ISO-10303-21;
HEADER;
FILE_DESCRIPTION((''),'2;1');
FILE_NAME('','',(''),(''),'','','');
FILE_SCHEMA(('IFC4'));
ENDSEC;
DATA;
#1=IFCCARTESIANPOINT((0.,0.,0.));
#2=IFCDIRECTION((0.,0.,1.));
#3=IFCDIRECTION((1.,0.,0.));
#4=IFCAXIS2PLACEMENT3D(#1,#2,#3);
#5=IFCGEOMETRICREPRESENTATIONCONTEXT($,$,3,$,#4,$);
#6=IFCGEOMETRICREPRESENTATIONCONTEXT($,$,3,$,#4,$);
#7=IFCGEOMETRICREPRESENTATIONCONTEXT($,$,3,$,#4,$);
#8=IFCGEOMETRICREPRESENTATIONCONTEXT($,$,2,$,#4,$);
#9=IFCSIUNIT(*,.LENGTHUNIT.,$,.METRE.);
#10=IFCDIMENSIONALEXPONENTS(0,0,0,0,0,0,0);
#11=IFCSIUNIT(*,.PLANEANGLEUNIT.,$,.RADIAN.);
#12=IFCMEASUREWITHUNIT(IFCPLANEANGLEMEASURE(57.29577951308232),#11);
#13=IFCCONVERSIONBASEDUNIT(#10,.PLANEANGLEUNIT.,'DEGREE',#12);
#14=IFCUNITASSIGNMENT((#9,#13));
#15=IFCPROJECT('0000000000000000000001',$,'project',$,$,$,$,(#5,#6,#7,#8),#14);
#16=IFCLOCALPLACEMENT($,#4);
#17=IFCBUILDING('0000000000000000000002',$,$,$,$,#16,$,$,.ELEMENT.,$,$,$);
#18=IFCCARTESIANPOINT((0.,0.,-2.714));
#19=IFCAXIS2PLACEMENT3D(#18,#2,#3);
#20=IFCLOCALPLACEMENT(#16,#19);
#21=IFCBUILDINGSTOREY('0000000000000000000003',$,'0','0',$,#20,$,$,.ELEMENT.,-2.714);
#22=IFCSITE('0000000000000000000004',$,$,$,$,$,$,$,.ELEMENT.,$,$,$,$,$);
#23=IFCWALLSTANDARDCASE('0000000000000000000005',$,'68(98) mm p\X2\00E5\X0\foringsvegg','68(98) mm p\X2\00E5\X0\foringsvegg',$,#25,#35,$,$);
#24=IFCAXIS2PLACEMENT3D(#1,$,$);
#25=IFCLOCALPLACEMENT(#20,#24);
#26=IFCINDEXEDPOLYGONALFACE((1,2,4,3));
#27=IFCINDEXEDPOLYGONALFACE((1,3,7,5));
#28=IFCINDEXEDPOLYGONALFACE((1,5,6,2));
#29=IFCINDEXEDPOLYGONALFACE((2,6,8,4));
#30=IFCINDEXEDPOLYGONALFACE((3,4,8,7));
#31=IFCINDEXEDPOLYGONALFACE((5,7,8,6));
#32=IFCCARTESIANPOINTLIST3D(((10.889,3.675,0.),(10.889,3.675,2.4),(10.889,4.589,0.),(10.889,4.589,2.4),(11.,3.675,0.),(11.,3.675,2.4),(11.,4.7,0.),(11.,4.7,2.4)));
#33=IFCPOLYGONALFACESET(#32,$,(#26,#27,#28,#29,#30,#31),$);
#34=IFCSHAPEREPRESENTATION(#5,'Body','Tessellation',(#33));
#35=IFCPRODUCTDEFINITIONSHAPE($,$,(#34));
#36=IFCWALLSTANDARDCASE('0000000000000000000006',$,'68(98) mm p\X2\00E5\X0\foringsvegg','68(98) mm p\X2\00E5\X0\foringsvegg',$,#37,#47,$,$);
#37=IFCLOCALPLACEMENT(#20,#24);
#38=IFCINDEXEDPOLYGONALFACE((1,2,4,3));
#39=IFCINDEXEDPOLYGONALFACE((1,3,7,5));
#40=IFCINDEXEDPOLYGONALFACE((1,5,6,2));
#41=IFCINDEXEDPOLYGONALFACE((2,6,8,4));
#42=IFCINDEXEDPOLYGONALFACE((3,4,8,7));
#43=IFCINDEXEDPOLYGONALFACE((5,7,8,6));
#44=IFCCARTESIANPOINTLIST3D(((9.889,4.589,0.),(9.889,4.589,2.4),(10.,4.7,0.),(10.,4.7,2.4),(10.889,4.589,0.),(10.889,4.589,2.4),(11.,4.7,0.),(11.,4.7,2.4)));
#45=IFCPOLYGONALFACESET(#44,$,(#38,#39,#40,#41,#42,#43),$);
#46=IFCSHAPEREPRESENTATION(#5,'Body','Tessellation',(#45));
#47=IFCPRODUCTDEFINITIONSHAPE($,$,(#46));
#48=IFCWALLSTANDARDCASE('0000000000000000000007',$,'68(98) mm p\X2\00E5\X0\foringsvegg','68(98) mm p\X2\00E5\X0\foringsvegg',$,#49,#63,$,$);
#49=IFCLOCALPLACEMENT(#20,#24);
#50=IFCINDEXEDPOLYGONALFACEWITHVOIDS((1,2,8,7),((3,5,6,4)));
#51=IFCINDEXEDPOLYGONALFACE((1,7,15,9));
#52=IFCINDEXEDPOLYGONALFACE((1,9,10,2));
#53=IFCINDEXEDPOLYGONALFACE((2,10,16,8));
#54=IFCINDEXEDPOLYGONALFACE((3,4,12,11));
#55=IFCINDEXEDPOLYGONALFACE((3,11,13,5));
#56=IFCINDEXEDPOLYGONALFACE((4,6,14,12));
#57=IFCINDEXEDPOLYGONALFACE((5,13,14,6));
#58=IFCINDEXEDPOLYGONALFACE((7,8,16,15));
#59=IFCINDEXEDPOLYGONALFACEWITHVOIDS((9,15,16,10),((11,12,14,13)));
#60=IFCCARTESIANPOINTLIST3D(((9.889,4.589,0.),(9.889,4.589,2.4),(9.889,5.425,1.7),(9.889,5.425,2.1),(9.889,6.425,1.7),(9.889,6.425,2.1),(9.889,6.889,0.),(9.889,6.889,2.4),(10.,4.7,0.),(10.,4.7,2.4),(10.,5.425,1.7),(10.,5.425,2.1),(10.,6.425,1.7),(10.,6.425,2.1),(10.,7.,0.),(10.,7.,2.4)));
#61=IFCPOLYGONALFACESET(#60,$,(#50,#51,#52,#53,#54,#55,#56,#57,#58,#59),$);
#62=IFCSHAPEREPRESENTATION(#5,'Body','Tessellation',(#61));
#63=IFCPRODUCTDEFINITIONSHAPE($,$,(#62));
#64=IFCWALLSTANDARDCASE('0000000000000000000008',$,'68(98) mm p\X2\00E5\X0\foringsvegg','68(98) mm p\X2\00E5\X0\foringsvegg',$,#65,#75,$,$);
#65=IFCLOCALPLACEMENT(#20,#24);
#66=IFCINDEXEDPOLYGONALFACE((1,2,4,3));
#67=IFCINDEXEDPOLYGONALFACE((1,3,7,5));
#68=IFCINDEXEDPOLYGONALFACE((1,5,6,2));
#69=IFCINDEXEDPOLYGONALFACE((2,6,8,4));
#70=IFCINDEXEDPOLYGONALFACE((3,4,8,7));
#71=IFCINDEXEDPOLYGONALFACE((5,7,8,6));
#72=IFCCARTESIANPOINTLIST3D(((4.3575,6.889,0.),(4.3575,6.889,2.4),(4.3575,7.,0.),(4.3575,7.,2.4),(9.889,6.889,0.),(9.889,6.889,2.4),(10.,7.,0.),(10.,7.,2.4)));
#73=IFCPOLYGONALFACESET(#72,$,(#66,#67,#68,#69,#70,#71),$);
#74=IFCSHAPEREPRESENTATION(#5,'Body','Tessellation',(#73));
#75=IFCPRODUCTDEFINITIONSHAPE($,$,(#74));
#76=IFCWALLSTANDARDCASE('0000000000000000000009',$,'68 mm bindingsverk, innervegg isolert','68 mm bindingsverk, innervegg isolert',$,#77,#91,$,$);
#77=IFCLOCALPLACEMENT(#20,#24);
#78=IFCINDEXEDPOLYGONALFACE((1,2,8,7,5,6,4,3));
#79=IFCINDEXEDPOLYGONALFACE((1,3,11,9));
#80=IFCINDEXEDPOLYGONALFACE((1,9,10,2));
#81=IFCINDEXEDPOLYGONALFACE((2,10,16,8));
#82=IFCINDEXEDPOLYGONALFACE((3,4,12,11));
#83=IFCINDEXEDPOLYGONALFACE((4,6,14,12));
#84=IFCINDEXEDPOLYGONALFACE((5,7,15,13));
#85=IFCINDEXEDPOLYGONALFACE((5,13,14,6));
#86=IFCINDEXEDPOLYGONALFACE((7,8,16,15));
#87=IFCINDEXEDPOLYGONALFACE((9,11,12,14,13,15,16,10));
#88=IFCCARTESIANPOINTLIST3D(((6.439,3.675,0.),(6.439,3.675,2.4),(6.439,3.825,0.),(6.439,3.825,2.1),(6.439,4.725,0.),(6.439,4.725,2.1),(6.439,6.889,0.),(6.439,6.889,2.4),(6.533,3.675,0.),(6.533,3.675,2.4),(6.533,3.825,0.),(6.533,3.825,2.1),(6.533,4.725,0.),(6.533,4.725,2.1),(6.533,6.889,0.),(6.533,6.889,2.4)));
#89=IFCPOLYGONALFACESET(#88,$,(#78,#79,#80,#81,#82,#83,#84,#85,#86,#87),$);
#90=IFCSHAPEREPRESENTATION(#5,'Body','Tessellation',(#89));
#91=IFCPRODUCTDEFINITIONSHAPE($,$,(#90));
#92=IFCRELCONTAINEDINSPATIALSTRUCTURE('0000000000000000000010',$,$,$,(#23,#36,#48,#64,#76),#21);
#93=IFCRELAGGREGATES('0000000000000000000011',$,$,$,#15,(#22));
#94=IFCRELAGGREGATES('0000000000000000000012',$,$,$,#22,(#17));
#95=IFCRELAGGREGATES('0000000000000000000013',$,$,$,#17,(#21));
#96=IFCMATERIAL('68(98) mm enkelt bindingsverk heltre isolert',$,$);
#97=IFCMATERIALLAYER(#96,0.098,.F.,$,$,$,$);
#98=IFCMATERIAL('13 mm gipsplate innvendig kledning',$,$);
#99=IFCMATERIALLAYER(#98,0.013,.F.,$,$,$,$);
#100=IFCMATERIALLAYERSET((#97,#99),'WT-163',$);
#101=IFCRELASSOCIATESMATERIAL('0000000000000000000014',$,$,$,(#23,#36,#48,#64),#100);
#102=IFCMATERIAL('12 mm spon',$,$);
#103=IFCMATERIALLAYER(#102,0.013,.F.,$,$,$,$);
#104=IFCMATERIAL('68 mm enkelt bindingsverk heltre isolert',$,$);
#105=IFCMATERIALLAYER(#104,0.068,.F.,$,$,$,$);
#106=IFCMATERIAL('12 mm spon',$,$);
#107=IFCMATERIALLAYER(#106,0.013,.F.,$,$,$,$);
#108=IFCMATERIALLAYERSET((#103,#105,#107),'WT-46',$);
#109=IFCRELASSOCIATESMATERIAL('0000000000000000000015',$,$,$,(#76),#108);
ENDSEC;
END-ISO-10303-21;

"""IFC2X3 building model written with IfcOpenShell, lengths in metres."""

from ifc_helpers import new_model, entity, si_unit, converted_unit, frame, origin_with_axes, place, context, project, spatial, polyline, outline, extrude, material, layer, layer_set, layer_usage, element, save


model = new_model("IFC2X3")

# Units and contexts
context_of_model_1 = context(None, 3, world=origin_with_axes())
context_of_model_2 = context(None, 3, world=origin_with_axes())
context_of_model_3 = context(None, 3, world=origin_with_axes())
context_of_model_4 = context(None, 2, world=origin_with_axes())
ifc_project = project(units=[si_unit("LENGTHUNIT", "METRE"), converted_unit("PLANEANGLEUNIT", "DEGREE", entity("IfcPlaneAngleMeasure", 57.29577951308232), si_unit("PLANEANGLEUNIT", "RADIAN"), dimensions=[0, 0, 0, 0, 0, 0, 0])], contexts=[context_of_model_1, context_of_model_2, context_of_model_3, context_of_model_4])

# Site, building, storey
site = spatial("IfcSite", under=ifc_project, CompositionType="ELEMENT")
building_placement = place(None, origin_with_axes())
building = spatial("IfcBuilding", under=site, at=building_placement, CompositionType="ELEMENT")
storey_placement = place(building_placement, frame((0.0, 0.0, -2.714), z_axis=(0.0, 0.0, 1.0), x_axis=(1.0, 0.0, 0.0)))
storey = spatial("IfcBuildingStorey", under=building, at=storey_placement, Name="0", Description="0", CompositionType="ELEMENT", Elevation=-2.714)

# Walls
ifc_material_1 = material(Name="68(98) mm enkelt bindingsverk heltre isolert")
ifc_layer_1 = layer(ifc_material_1, 0.098, ventilated=False)
ifc_material_2 = material(Name="13 mm gipsplate innvendig kledning")
ifc_layer_2 = layer(ifc_material_2, 0.013, ventilated=False)
ifc_layer_set_1 = layer_set([ifc_layer_1, ifc_layer_2], Name="WT-163")
ifc_layer_usage_1 = layer_usage(ifc_layer_set_1, "AXIS2", "POSITIVE", 0.0)
wall_1_placement = place(storey_placement, frame((11.0, 3.675, 0.0), z_axis=(0.0, 0.0, 1.0), x_axis=(0.0, 1.0, 0.0)))
element("IfcWallStandardCase", 1, at=wall_1_placement, inside=storey, material=ifc_layer_usage_1, Name="68(98) mm påforingsvegg", Description="68(98) mm påforingsvegg", context=context_of_model_1, shape_type="SweptSolid", body=[
    extrude(outline(polyline([(0.0, 0.0), (1.025, 0.0), (0.914, 0.111), (0.0, 0.111), (0.0, 0.0)])), frame((0.0, 0.0, 0.0), z_axis=(0.0, 0.0, 1.0), x_axis=(1.0, 0.0, 0.0)), (0.0, 0.0, 1.0), 2.4),
])
wall_2_placement = place(storey_placement, frame((11.0, 4.7, 0.0), z_axis=(0.0, 0.0, 1.0), x_axis=(-1.0, 0.0, 0.0)))
element("IfcWallStandardCase", 2, at=wall_2_placement, inside=storey, material=ifc_layer_usage_1, Name="68(98) mm påforingsvegg", Description="68(98) mm påforingsvegg", context=context_of_model_1, shape_type="SweptSolid", body=[
    extrude(outline(polyline([(0.0, 0.0), (1.0, 0.0), (1.111, 0.111), (0.111, 0.111), (0.0, 0.0)])), frame((0.0, 0.0, 0.0), z_axis=(0.0, 0.0, 1.0), x_axis=(1.0, 0.0, 0.0)), (0.0, 0.0, 1.0), 2.4),
])

# Wall, opening
wall_3_placement = place(storey_placement, frame((10.0, 4.7, 0.0), z_axis=(0.0, 0.0, 1.0), x_axis=(0.0, 1.0, 0.0)))
wall_3 = element("IfcWallStandardCase", 3, at=wall_3_placement, inside=storey, material=ifc_layer_usage_1, Name="68(98) mm påforingsvegg", Description="68(98) mm påforingsvegg", context=context_of_model_1, shape_type="SweptSolid", body=[
    extrude(outline(polyline([(0.0, 0.0), (2.3, 0.0), (2.189, 0.111), (-0.111, 0.111), (0.0, 0.0)])), frame((0.0, 0.0, 0.0), z_axis=(0.0, 0.0, 1.0), x_axis=(1.0, 0.000001, 0.0)), (0.0, 0.0, 1.0), 2.4),
])
opening_1_placement = place(wall_3_placement, frame((0.725, 0.0, 1.7), z_axis=(0.0, 0.0, 1.0), x_axis=(1.0, 0.0, 0.0)))
element("IfcOpeningElement", 4, at=opening_1_placement, inside=storey, cuts=wall_3, context=context_of_model_1, shape_type="SweptSolid", body=[
    extrude(outline(polyline([(0.0, 0.0), (0.4, 0.0), (0.4, 1.0), (0.0, 1.0), (0.0, 0.0)])), frame((0.0, 0.0, 0.0), z_axis=(-0.000001, 1.0, 0.0), x_axis=(0.0, 0.0, 1.0)), (0.0, 0.000001, 1.0), 0.111),
])

# Wall
wall_4_placement = place(storey_placement, frame((10.0, 7.0, 0.0), z_axis=(0.0, 0.0, 1.0), x_axis=(-1.0, 0.0, 0.0)))
element("IfcWallStandardCase", 5, at=wall_4_placement, inside=storey, material=ifc_layer_usage_1, Name="68(98) mm påforingsvegg", Description="68(98) mm påforingsvegg", context=context_of_model_1, shape_type="SweptSolid", body=[
    extrude(outline(polyline([(0.0, 0.0), (5.6425, 0.0), (5.6425, 0.111), (0.111, 0.111), (0.0, 0.0)])), frame((0.0, 0.0, 0.0), z_axis=(0.0, 0.0, 1.0), x_axis=(1.0, 0.000001, 0.0)), (0.0, 0.0, 1.0), 2.4),
])

# Wall, opening
ifc_material_3 = material(Name="12 mm spon")
ifc_layer_3 = layer(ifc_material_3, 0.013, ventilated=False)
ifc_material_4 = material(Name="68 mm enkelt bindingsverk heltre isolert")
ifc_layer_4 = layer(ifc_material_4, 0.068, ventilated=False)
ifc_material_5 = material(Name="12 mm spon")
ifc_layer_5 = layer(ifc_material_5, 0.013, ventilated=False)
ifc_layer_set_2 = layer_set([ifc_layer_3, ifc_layer_4, ifc_layer_5], Name="WT-46")
ifc_layer_usage_2 = layer_usage(ifc_layer_set_2, "AXIS2", "POSITIVE", 0.0)
wall_5_placement = place(storey_placement, frame((6.533, 3.675, 0.0), z_axis=(0.0, 0.0, 1.0), x_axis=(0.0, 1.0, 0.0)))
wall_5 = element("IfcWallStandardCase", 6, at=wall_5_placement, inside=storey, material=ifc_layer_usage_2, Name="68 mm bindingsverk, innervegg isolert", Description="68 mm bindingsverk, innervegg isolert", context=context_of_model_1, shape_type="SweptSolid", body=[
    extrude(outline(polyline([(0.0, 0.0), (3.214, 0.0), (3.214, 0.094), (0.0, 0.094), (0.0, 0.0)])), frame((0.0, 0.0, 0.0), z_axis=(0.0, 0.0, 1.0), x_axis=(1.0, 0.0, 0.0)), (0.0, 0.0, 1.0), 2.4),
])
opening_2_placement = place(wall_5_placement, frame((0.15, 0.0, 0.0), z_axis=(0.0, 0.0, 1.0), x_axis=(1.0, 0.0, 0.0)))
element("IfcOpeningElement", 7, at=opening_2_placement, inside=storey, cuts=wall_5, context=context_of_model_1, shape_type="SweptSolid", body=[
    extrude(outline(polyline([(0.0, 0.0), (2.1, 0.0), (2.1, 0.9), (0.0, 0.9), (0.0, 0.0)])), frame((0.0, 0.0, 0.0), z_axis=(0.0, 1.0, 0.0), x_axis=(0.0, 0.0, 1.0)), (0.0, 0.0, 1.0), 0.094),
])

save(model, "model.ifc")
